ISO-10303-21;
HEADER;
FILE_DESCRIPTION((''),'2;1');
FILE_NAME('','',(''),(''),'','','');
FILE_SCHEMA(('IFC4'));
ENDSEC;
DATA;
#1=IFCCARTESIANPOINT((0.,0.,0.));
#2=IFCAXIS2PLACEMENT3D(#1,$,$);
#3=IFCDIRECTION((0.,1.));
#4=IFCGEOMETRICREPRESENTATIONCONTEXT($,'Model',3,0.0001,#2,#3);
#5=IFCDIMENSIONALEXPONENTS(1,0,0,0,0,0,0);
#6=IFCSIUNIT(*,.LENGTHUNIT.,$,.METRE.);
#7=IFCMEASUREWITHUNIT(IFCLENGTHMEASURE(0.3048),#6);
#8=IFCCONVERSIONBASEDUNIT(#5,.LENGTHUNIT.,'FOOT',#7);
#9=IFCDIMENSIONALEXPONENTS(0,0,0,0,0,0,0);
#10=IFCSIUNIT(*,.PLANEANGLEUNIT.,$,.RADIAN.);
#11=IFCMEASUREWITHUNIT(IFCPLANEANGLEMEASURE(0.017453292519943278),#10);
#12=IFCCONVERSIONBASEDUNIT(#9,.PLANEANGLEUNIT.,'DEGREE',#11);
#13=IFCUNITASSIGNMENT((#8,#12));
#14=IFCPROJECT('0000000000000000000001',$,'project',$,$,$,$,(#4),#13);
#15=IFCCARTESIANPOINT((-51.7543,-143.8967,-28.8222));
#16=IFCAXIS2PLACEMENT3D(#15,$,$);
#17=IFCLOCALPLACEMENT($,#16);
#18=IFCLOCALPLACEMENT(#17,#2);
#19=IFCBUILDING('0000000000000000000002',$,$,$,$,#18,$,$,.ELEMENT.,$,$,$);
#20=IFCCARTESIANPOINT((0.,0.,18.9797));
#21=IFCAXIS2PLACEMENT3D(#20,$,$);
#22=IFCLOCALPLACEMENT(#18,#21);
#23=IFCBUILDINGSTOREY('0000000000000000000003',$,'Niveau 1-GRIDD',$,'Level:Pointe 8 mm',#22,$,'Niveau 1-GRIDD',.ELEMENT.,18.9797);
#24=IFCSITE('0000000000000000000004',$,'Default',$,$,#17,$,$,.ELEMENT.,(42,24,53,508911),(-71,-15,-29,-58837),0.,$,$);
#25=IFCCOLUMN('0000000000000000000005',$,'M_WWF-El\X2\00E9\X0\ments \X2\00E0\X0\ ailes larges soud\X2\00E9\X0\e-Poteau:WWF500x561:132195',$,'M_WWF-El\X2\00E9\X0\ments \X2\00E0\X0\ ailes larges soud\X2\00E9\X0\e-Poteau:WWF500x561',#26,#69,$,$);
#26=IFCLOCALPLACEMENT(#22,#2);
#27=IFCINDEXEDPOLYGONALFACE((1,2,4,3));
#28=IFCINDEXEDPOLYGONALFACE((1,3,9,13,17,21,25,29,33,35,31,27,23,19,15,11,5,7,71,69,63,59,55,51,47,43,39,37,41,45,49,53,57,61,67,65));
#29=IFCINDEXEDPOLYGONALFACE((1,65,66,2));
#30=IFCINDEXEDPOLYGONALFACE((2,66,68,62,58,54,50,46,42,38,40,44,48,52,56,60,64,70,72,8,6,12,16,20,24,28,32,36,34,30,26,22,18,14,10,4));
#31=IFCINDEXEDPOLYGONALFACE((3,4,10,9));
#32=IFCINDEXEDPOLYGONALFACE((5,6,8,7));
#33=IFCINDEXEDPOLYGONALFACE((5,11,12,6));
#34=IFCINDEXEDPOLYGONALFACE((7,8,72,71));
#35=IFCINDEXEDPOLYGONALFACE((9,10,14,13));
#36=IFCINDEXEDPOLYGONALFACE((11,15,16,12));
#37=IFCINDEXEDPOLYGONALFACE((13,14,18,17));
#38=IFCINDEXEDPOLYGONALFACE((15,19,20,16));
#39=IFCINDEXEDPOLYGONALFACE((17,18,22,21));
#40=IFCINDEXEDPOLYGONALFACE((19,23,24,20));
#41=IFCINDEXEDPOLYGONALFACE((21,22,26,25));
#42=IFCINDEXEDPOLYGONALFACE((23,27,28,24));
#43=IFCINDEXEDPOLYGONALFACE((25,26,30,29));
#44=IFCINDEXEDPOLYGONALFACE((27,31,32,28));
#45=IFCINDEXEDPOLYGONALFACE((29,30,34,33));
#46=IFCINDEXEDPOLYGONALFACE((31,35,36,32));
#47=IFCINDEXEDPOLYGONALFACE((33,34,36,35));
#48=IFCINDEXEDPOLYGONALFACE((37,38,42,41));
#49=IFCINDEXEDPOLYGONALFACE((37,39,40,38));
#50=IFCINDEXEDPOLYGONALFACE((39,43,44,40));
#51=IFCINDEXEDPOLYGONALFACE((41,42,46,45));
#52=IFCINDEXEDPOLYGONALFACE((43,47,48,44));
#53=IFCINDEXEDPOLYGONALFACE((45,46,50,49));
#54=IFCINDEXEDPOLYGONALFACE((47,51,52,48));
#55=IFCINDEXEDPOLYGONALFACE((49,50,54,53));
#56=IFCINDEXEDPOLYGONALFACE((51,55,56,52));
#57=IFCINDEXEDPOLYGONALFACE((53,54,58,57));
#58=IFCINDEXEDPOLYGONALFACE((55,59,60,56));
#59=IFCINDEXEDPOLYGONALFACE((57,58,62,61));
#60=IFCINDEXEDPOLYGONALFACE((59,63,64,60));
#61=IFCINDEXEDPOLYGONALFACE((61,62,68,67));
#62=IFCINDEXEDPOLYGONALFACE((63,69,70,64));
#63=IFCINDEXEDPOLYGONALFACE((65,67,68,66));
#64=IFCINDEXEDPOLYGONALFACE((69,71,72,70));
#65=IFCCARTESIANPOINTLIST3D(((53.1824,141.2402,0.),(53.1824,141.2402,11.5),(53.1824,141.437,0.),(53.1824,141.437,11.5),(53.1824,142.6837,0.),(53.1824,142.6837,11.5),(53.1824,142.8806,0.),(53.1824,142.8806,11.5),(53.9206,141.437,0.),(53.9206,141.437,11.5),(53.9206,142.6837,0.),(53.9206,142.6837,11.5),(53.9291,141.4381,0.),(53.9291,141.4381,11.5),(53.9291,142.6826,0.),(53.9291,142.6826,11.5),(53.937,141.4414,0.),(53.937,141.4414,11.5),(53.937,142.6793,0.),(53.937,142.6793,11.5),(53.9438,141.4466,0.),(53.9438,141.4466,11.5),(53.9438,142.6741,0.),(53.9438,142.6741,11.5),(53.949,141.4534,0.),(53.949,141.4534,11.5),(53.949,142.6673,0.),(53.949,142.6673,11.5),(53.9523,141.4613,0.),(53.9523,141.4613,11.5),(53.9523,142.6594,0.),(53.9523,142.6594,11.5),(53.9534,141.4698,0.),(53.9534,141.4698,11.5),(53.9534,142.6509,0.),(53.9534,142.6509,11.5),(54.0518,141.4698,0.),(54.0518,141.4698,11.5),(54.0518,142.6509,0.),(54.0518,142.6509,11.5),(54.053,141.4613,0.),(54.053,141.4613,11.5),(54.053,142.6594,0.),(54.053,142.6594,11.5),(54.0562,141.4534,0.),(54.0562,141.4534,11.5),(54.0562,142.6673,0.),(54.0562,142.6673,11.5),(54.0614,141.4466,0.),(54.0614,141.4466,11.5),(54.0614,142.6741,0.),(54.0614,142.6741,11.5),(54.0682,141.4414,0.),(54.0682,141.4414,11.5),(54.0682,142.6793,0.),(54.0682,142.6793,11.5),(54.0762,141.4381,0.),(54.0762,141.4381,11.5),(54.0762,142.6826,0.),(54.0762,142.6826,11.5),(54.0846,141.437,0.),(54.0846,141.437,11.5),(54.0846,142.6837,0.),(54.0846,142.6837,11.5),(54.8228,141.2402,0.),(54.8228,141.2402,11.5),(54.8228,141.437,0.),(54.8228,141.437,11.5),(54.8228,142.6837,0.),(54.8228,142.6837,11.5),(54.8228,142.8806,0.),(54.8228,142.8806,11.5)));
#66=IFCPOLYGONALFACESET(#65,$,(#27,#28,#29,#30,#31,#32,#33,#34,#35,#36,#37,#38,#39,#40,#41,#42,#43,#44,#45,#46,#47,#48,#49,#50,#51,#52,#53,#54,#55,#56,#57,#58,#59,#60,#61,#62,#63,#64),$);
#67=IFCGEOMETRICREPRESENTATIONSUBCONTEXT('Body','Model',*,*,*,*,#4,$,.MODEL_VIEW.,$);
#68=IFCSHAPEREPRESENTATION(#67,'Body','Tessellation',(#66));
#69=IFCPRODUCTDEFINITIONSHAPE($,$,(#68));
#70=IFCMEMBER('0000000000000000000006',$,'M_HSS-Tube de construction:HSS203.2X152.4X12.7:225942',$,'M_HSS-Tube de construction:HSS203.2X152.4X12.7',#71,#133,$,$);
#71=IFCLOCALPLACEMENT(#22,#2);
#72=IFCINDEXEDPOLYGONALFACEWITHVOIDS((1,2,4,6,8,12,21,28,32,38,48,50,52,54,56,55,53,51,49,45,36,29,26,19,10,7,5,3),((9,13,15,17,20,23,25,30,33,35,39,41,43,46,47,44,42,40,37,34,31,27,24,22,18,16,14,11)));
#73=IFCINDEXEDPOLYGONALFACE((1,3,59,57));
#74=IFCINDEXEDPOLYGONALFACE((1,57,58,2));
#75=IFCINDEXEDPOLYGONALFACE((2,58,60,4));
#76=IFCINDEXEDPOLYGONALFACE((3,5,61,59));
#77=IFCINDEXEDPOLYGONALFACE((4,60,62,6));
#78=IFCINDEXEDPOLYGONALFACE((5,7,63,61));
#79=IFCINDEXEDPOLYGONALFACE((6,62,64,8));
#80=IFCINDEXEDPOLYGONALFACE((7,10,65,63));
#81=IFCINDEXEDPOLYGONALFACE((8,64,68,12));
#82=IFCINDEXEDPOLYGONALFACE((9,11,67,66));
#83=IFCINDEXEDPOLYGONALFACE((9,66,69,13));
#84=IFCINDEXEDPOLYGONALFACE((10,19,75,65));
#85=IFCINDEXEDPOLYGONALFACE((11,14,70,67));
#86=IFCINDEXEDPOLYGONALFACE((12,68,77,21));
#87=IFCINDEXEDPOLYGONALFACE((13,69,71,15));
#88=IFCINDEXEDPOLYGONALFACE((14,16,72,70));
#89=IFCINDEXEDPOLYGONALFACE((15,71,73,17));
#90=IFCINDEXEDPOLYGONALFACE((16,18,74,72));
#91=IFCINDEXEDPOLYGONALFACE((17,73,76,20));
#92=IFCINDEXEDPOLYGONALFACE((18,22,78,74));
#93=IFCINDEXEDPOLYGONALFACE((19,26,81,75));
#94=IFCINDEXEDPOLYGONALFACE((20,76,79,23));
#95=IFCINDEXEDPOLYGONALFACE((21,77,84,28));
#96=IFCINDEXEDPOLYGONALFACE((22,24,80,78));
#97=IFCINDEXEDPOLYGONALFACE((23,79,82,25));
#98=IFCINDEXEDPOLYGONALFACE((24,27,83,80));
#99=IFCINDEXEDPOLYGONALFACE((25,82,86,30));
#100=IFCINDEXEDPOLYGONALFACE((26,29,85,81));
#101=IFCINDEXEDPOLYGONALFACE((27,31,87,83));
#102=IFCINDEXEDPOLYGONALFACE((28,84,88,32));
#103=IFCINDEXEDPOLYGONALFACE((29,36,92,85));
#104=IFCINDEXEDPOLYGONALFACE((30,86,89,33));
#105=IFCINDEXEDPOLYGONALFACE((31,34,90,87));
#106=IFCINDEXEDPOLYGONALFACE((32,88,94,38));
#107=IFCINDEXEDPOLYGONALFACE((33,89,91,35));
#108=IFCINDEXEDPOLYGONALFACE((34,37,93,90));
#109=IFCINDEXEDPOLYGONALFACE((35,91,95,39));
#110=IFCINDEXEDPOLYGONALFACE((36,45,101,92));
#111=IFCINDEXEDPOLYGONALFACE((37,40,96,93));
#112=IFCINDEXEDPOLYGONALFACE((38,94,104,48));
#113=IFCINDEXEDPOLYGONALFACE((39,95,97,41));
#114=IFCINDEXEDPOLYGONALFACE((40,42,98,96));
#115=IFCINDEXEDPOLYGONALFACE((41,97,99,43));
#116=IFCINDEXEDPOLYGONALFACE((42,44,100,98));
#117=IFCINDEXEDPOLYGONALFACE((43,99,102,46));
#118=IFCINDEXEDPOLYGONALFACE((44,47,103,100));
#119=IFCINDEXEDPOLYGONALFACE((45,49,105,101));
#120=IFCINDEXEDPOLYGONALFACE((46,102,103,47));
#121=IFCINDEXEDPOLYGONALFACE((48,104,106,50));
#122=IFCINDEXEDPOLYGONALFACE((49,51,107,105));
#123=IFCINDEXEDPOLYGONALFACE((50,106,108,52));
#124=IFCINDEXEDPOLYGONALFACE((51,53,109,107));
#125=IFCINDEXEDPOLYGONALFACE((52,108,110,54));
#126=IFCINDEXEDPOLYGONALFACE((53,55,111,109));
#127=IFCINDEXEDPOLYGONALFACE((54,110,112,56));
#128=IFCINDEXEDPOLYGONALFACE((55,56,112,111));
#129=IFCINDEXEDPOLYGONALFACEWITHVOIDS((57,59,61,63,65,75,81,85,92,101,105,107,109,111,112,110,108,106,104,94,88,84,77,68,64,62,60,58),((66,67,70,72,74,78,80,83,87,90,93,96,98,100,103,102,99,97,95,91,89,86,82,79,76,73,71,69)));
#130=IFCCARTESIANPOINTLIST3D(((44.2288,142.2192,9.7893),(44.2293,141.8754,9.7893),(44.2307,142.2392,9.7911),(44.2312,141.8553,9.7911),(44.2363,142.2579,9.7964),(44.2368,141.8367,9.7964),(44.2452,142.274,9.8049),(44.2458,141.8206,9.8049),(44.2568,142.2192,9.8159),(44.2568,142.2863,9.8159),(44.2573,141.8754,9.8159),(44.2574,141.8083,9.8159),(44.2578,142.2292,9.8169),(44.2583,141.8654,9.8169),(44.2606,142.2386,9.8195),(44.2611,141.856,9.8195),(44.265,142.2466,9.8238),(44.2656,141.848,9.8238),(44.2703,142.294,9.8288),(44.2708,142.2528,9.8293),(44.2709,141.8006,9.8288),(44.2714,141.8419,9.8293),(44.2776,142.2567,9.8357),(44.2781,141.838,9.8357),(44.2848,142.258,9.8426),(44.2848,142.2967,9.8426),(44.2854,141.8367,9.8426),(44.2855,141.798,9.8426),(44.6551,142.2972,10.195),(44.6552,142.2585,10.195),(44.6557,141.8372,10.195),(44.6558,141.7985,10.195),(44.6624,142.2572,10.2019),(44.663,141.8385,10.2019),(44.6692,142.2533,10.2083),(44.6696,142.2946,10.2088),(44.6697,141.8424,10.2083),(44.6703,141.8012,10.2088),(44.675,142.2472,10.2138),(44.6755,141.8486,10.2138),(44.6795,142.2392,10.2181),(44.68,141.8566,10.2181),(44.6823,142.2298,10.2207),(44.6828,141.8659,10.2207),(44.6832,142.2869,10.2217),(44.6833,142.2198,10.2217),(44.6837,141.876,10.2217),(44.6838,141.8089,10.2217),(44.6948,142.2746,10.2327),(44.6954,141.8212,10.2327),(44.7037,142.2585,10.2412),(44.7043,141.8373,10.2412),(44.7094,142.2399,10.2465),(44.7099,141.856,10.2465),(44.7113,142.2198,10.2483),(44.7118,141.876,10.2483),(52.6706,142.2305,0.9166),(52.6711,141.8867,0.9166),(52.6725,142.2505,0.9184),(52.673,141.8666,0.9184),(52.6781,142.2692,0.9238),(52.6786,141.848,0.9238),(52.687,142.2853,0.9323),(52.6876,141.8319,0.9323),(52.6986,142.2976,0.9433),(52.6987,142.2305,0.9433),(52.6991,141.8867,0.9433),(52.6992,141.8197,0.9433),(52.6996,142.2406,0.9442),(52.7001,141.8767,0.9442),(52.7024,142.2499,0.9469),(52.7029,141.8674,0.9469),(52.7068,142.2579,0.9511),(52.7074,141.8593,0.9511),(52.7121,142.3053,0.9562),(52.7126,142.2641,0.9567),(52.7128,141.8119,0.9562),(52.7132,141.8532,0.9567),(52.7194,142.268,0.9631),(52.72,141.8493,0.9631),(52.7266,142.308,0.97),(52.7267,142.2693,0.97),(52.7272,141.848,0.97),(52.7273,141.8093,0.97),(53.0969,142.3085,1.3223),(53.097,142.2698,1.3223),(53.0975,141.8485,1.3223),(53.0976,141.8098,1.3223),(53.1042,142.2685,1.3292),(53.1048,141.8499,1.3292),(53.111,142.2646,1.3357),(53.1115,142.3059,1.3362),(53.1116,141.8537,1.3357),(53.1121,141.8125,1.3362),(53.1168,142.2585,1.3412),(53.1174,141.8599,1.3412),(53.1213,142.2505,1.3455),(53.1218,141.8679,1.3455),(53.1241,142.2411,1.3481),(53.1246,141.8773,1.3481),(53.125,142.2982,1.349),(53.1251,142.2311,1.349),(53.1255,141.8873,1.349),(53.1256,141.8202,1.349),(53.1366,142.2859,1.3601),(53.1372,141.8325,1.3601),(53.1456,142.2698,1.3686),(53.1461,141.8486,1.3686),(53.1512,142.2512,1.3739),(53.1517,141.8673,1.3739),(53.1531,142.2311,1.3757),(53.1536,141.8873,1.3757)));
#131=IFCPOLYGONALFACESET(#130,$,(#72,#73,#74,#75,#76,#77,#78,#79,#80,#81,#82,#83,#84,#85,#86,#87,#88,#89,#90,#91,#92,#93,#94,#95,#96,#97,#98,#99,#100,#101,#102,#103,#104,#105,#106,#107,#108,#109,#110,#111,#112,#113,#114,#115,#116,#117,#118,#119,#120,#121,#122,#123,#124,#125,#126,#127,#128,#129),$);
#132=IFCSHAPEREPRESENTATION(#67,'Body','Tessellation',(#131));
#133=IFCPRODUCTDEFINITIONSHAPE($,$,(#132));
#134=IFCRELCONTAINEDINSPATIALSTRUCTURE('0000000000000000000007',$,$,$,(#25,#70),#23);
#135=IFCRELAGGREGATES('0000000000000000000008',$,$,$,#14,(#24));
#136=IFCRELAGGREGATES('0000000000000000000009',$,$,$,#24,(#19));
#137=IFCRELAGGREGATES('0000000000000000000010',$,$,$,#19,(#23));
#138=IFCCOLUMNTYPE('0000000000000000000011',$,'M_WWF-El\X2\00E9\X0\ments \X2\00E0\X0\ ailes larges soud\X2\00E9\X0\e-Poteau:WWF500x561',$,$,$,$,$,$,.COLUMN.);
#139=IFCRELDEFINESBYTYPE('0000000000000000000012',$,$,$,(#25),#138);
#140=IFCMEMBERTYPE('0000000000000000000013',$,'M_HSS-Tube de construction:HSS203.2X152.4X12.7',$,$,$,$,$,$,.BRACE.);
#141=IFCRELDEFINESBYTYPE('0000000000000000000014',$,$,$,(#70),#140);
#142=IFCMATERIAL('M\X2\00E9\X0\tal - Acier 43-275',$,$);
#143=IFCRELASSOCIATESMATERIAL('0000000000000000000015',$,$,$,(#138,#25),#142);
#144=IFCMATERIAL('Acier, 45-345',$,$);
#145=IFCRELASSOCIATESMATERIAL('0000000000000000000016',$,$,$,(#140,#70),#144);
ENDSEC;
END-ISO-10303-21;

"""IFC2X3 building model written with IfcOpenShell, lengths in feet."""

from ifc_helpers import new_model, entity, si_unit, converted_unit, direction, frame, frame_2d, origin, origin_2d_with_axis, place, context, subcontext, project, spatial, polyline, circle_curve, parameter, trimmed, segment, composite_curve, i_section, outline, extrude, source, transform, mapped, material, type_object, type_shapes, element, save


model = new_model("IFC2X3")

# Units and contexts
model_context = context("Model", 3, precision=0.0001, world=origin(), true_north=direction((0.0, 1.0)))
body_context = subcontext(model_context, "Body", "Model", "MODEL_VIEW")
ifc_project = project(units=[converted_unit("LENGTHUNIT", "FOOT", entity("IfcLengthMeasure", 0.3048), si_unit("LENGTHUNIT", "METRE"), dimensions=[1, 0, 0, 0, 0, 0, 0]), converted_unit("PLANEANGLEUNIT", "DEGREE", entity("IfcPlaneAngleMeasure", 0.017453292519943278), si_unit("PLANEANGLEUNIT", "RADIAN"), dimensions=[0, 0, 0, 0, 0, 0, 0])], contexts=[model_context])

# Site, building, storey
site_placement = place(None, frame((-51.7543, -143.8967, -28.8222)))
site = spatial("IfcSite", under=ifc_project, at=site_placement, Name="Default", CompositionType="ELEMENT", RefLatitude=(42, 24, 53, 508911), RefLongitude=(-71, -15, -29, -58837), RefElevation=0.0)
building_placement = place(site_placement, origin())
building = spatial("IfcBuilding", under=site, at=building_placement, CompositionType="ELEMENT")
storey_placement = place(building_placement, frame((0.0, 0.0, 18.9797)))
storey = spatial("IfcBuildingStorey", under=building, at=storey_placement, Name="Niveau 1-GRIDD", ObjectType="Level:Pointe 8 mm", LongName="Niveau 1-GRIDD", CompositionType="ELEMENT", Elevation=18.9797)

# Column
ifc_material_1 = material(Name="Métal - Acier 43-275")
column_type = type_object("IfcColumnType", Name="M_WWF-Eléments à ailes larges soudée-Poteau:WWF500x561", PredefinedType="COLUMN", material=ifc_material_1)
shared_shape_1 = source(origin(), body_context, "Body", "SweptSolid", [
    extrude(i_section(OverallWidth=1.6404, OverallDepth=1.6404, WebThickness=0.0984, FlangeThickness=0.1969, FilletRadius=0.0328, at=origin_2d_with_axis()), frame((0.0, 0.0, 18.9797), z_axis=(0.0, 0.0, 1.0), x_axis=(-1.0, 0.0, 0.0)), (0.0, 0.0, 1.0), 11.5),
])
type_shapes(column_type, [shared_shape_1])
column_placement = place(storey_placement, frame((54.0026, 142.0604, -18.9797)))
element("IfcColumn", 1, at=column_placement, inside=storey, type_object=column_type, material=ifc_material_1, Name="M_WWF-Eléments à ailes larges soudée-Poteau:WWF500x561:132195", ObjectType="M_WWF-Eléments à ailes larges soudée-Poteau:WWF500x561", context=body_context, shape_type="MappedRepresentation", body=[
    mapped(shared_shape_1, transform((0.0, 0.0, 0.0), scale=1.0)),
])

# Member
ifc_material_2 = material(Name="Acier, 45-345")
member_type = type_object("IfcMemberType", Name="M_HSS-Tube de construction:HSS203.2X152.4X12.7", PredefinedType="BRACE", material=ifc_material_2)
shared_shape_2 = source(origin(), body_context, "Body", "SweptSolid", [
    extrude(outline(composite_curve([segment(trimmed(circle_curve(frame_2d((-0.1719, -0.2556), x_axis=(1.0, 0.0)), 0.0774), [parameter(180.0)], [parameter(270.0)], True, "PARAMETER"), True, "CONTINUOUS"), segment(polyline([(-0.1719, -0.333), (0.1719, -0.333)]), True, "CONTINUOUS"), segment(trimmed(circle_curve(frame_2d((0.1719, -0.2556), x_axis=(1.0, 0.0)), 0.0774), [parameter(270.0)], [parameter(0.0)], True, "PARAMETER"), True, "CONTINUOUS"), segment(polyline([(0.2493, -0.2556), (0.2493, 0.2556)]), True, "CONTINUOUS"), segment(trimmed(circle_curve(frame_2d((0.1719, 0.2556), x_axis=(1.0, 0.0)), 0.0774), [parameter(360.0)], [parameter(90.0)], True, "PARAMETER"), True, "CONTINUOUS"), segment(polyline([(0.1719, 0.333), (-0.1719, 0.333)]), True, "CONTINUOUS"), segment(trimmed(circle_curve(frame_2d((-0.1719, 0.2556), x_axis=(1.0, 0.0)), 0.0774), [parameter(90.0)], [parameter(180.0)], True, "PARAMETER"), True, "CONTINUOUS"), segment(polyline([(-0.2493, 0.2556), (-0.2493, -0.2556)]), True, "CONTINUOUS")], self_intersect=False), holes=[composite_curve([segment(polyline([(0.1719, -0.2943), (-0.1719, -0.2943)]), True, "CONTINUOUS"), segment(trimmed(circle_curve(frame_2d((-0.1719, -0.2556), x_axis=(1.0, 0.0)), 0.0387), [parameter(180.0)], [parameter(270.0)], True, "PARAMETER"), False, "CONTINUOUS"), segment(polyline([(-0.2106, -0.2556), (-0.2106, 0.2556)]), True, "CONTINUOUS"), segment(trimmed(circle_curve(frame_2d((-0.1719, 0.2556), x_axis=(1.0, 0.0)), 0.0387), [parameter(90.0)], [parameter(180.0)], True, "PARAMETER"), False, "CONTINUOUS"), segment(polyline([(-0.1719, 0.2943), (0.1719, 0.2943)]), True, "CONTINUOUS"), segment(trimmed(circle_curve(frame_2d((0.1719, 0.2556), x_axis=(1.0, 0.0)), 0.0387), [parameter(0.0)], [parameter(90.0)], True, "PARAMETER"), False, "CONTINUOUS"), segment(polyline([(0.2106, 0.2556), (0.2106, -0.2556)]), True, "CONTINUOUS"), segment(trimmed(circle_curve(frame_2d((0.1719, -0.2556), x_axis=(1.0, 0.0)), 0.0387), [parameter(270.0)], [parameter(0.0)], True, "PARAMETER"), False, "CONTINUOUS")], self_intersect=False)]), frame((-5.3324, 0.0, 0.0), z_axis=(1.0, 0.0, 0.0), x_axis=(0.0, -1.0, 0.0)), (0.0, 0.0, 1.0), 12.247),
])
type_shapes(member_type, [shared_shape_2])
member_placement = place(storey_placement, frame((49.2365, 142.054, 5.0094), z_axis=(0.724475, 0.000971, 0.6893), x_axis=(-0.689299, -0.000923, 0.724476)))
element("IfcMember", 2, at=member_placement, inside=storey, type_object=member_type, material=ifc_material_2, Name="M_HSS-Tube de construction:HSS203.2X152.4X12.7:225942", ObjectType="M_HSS-Tube de construction:HSS203.2X152.4X12.7", context=body_context, shape_type="MappedRepresentation", body=[
    mapped(shared_shape_2, transform((0.0, 0.0, 0.0), scale=1.0)),
])

save(model, "model.ifc")
